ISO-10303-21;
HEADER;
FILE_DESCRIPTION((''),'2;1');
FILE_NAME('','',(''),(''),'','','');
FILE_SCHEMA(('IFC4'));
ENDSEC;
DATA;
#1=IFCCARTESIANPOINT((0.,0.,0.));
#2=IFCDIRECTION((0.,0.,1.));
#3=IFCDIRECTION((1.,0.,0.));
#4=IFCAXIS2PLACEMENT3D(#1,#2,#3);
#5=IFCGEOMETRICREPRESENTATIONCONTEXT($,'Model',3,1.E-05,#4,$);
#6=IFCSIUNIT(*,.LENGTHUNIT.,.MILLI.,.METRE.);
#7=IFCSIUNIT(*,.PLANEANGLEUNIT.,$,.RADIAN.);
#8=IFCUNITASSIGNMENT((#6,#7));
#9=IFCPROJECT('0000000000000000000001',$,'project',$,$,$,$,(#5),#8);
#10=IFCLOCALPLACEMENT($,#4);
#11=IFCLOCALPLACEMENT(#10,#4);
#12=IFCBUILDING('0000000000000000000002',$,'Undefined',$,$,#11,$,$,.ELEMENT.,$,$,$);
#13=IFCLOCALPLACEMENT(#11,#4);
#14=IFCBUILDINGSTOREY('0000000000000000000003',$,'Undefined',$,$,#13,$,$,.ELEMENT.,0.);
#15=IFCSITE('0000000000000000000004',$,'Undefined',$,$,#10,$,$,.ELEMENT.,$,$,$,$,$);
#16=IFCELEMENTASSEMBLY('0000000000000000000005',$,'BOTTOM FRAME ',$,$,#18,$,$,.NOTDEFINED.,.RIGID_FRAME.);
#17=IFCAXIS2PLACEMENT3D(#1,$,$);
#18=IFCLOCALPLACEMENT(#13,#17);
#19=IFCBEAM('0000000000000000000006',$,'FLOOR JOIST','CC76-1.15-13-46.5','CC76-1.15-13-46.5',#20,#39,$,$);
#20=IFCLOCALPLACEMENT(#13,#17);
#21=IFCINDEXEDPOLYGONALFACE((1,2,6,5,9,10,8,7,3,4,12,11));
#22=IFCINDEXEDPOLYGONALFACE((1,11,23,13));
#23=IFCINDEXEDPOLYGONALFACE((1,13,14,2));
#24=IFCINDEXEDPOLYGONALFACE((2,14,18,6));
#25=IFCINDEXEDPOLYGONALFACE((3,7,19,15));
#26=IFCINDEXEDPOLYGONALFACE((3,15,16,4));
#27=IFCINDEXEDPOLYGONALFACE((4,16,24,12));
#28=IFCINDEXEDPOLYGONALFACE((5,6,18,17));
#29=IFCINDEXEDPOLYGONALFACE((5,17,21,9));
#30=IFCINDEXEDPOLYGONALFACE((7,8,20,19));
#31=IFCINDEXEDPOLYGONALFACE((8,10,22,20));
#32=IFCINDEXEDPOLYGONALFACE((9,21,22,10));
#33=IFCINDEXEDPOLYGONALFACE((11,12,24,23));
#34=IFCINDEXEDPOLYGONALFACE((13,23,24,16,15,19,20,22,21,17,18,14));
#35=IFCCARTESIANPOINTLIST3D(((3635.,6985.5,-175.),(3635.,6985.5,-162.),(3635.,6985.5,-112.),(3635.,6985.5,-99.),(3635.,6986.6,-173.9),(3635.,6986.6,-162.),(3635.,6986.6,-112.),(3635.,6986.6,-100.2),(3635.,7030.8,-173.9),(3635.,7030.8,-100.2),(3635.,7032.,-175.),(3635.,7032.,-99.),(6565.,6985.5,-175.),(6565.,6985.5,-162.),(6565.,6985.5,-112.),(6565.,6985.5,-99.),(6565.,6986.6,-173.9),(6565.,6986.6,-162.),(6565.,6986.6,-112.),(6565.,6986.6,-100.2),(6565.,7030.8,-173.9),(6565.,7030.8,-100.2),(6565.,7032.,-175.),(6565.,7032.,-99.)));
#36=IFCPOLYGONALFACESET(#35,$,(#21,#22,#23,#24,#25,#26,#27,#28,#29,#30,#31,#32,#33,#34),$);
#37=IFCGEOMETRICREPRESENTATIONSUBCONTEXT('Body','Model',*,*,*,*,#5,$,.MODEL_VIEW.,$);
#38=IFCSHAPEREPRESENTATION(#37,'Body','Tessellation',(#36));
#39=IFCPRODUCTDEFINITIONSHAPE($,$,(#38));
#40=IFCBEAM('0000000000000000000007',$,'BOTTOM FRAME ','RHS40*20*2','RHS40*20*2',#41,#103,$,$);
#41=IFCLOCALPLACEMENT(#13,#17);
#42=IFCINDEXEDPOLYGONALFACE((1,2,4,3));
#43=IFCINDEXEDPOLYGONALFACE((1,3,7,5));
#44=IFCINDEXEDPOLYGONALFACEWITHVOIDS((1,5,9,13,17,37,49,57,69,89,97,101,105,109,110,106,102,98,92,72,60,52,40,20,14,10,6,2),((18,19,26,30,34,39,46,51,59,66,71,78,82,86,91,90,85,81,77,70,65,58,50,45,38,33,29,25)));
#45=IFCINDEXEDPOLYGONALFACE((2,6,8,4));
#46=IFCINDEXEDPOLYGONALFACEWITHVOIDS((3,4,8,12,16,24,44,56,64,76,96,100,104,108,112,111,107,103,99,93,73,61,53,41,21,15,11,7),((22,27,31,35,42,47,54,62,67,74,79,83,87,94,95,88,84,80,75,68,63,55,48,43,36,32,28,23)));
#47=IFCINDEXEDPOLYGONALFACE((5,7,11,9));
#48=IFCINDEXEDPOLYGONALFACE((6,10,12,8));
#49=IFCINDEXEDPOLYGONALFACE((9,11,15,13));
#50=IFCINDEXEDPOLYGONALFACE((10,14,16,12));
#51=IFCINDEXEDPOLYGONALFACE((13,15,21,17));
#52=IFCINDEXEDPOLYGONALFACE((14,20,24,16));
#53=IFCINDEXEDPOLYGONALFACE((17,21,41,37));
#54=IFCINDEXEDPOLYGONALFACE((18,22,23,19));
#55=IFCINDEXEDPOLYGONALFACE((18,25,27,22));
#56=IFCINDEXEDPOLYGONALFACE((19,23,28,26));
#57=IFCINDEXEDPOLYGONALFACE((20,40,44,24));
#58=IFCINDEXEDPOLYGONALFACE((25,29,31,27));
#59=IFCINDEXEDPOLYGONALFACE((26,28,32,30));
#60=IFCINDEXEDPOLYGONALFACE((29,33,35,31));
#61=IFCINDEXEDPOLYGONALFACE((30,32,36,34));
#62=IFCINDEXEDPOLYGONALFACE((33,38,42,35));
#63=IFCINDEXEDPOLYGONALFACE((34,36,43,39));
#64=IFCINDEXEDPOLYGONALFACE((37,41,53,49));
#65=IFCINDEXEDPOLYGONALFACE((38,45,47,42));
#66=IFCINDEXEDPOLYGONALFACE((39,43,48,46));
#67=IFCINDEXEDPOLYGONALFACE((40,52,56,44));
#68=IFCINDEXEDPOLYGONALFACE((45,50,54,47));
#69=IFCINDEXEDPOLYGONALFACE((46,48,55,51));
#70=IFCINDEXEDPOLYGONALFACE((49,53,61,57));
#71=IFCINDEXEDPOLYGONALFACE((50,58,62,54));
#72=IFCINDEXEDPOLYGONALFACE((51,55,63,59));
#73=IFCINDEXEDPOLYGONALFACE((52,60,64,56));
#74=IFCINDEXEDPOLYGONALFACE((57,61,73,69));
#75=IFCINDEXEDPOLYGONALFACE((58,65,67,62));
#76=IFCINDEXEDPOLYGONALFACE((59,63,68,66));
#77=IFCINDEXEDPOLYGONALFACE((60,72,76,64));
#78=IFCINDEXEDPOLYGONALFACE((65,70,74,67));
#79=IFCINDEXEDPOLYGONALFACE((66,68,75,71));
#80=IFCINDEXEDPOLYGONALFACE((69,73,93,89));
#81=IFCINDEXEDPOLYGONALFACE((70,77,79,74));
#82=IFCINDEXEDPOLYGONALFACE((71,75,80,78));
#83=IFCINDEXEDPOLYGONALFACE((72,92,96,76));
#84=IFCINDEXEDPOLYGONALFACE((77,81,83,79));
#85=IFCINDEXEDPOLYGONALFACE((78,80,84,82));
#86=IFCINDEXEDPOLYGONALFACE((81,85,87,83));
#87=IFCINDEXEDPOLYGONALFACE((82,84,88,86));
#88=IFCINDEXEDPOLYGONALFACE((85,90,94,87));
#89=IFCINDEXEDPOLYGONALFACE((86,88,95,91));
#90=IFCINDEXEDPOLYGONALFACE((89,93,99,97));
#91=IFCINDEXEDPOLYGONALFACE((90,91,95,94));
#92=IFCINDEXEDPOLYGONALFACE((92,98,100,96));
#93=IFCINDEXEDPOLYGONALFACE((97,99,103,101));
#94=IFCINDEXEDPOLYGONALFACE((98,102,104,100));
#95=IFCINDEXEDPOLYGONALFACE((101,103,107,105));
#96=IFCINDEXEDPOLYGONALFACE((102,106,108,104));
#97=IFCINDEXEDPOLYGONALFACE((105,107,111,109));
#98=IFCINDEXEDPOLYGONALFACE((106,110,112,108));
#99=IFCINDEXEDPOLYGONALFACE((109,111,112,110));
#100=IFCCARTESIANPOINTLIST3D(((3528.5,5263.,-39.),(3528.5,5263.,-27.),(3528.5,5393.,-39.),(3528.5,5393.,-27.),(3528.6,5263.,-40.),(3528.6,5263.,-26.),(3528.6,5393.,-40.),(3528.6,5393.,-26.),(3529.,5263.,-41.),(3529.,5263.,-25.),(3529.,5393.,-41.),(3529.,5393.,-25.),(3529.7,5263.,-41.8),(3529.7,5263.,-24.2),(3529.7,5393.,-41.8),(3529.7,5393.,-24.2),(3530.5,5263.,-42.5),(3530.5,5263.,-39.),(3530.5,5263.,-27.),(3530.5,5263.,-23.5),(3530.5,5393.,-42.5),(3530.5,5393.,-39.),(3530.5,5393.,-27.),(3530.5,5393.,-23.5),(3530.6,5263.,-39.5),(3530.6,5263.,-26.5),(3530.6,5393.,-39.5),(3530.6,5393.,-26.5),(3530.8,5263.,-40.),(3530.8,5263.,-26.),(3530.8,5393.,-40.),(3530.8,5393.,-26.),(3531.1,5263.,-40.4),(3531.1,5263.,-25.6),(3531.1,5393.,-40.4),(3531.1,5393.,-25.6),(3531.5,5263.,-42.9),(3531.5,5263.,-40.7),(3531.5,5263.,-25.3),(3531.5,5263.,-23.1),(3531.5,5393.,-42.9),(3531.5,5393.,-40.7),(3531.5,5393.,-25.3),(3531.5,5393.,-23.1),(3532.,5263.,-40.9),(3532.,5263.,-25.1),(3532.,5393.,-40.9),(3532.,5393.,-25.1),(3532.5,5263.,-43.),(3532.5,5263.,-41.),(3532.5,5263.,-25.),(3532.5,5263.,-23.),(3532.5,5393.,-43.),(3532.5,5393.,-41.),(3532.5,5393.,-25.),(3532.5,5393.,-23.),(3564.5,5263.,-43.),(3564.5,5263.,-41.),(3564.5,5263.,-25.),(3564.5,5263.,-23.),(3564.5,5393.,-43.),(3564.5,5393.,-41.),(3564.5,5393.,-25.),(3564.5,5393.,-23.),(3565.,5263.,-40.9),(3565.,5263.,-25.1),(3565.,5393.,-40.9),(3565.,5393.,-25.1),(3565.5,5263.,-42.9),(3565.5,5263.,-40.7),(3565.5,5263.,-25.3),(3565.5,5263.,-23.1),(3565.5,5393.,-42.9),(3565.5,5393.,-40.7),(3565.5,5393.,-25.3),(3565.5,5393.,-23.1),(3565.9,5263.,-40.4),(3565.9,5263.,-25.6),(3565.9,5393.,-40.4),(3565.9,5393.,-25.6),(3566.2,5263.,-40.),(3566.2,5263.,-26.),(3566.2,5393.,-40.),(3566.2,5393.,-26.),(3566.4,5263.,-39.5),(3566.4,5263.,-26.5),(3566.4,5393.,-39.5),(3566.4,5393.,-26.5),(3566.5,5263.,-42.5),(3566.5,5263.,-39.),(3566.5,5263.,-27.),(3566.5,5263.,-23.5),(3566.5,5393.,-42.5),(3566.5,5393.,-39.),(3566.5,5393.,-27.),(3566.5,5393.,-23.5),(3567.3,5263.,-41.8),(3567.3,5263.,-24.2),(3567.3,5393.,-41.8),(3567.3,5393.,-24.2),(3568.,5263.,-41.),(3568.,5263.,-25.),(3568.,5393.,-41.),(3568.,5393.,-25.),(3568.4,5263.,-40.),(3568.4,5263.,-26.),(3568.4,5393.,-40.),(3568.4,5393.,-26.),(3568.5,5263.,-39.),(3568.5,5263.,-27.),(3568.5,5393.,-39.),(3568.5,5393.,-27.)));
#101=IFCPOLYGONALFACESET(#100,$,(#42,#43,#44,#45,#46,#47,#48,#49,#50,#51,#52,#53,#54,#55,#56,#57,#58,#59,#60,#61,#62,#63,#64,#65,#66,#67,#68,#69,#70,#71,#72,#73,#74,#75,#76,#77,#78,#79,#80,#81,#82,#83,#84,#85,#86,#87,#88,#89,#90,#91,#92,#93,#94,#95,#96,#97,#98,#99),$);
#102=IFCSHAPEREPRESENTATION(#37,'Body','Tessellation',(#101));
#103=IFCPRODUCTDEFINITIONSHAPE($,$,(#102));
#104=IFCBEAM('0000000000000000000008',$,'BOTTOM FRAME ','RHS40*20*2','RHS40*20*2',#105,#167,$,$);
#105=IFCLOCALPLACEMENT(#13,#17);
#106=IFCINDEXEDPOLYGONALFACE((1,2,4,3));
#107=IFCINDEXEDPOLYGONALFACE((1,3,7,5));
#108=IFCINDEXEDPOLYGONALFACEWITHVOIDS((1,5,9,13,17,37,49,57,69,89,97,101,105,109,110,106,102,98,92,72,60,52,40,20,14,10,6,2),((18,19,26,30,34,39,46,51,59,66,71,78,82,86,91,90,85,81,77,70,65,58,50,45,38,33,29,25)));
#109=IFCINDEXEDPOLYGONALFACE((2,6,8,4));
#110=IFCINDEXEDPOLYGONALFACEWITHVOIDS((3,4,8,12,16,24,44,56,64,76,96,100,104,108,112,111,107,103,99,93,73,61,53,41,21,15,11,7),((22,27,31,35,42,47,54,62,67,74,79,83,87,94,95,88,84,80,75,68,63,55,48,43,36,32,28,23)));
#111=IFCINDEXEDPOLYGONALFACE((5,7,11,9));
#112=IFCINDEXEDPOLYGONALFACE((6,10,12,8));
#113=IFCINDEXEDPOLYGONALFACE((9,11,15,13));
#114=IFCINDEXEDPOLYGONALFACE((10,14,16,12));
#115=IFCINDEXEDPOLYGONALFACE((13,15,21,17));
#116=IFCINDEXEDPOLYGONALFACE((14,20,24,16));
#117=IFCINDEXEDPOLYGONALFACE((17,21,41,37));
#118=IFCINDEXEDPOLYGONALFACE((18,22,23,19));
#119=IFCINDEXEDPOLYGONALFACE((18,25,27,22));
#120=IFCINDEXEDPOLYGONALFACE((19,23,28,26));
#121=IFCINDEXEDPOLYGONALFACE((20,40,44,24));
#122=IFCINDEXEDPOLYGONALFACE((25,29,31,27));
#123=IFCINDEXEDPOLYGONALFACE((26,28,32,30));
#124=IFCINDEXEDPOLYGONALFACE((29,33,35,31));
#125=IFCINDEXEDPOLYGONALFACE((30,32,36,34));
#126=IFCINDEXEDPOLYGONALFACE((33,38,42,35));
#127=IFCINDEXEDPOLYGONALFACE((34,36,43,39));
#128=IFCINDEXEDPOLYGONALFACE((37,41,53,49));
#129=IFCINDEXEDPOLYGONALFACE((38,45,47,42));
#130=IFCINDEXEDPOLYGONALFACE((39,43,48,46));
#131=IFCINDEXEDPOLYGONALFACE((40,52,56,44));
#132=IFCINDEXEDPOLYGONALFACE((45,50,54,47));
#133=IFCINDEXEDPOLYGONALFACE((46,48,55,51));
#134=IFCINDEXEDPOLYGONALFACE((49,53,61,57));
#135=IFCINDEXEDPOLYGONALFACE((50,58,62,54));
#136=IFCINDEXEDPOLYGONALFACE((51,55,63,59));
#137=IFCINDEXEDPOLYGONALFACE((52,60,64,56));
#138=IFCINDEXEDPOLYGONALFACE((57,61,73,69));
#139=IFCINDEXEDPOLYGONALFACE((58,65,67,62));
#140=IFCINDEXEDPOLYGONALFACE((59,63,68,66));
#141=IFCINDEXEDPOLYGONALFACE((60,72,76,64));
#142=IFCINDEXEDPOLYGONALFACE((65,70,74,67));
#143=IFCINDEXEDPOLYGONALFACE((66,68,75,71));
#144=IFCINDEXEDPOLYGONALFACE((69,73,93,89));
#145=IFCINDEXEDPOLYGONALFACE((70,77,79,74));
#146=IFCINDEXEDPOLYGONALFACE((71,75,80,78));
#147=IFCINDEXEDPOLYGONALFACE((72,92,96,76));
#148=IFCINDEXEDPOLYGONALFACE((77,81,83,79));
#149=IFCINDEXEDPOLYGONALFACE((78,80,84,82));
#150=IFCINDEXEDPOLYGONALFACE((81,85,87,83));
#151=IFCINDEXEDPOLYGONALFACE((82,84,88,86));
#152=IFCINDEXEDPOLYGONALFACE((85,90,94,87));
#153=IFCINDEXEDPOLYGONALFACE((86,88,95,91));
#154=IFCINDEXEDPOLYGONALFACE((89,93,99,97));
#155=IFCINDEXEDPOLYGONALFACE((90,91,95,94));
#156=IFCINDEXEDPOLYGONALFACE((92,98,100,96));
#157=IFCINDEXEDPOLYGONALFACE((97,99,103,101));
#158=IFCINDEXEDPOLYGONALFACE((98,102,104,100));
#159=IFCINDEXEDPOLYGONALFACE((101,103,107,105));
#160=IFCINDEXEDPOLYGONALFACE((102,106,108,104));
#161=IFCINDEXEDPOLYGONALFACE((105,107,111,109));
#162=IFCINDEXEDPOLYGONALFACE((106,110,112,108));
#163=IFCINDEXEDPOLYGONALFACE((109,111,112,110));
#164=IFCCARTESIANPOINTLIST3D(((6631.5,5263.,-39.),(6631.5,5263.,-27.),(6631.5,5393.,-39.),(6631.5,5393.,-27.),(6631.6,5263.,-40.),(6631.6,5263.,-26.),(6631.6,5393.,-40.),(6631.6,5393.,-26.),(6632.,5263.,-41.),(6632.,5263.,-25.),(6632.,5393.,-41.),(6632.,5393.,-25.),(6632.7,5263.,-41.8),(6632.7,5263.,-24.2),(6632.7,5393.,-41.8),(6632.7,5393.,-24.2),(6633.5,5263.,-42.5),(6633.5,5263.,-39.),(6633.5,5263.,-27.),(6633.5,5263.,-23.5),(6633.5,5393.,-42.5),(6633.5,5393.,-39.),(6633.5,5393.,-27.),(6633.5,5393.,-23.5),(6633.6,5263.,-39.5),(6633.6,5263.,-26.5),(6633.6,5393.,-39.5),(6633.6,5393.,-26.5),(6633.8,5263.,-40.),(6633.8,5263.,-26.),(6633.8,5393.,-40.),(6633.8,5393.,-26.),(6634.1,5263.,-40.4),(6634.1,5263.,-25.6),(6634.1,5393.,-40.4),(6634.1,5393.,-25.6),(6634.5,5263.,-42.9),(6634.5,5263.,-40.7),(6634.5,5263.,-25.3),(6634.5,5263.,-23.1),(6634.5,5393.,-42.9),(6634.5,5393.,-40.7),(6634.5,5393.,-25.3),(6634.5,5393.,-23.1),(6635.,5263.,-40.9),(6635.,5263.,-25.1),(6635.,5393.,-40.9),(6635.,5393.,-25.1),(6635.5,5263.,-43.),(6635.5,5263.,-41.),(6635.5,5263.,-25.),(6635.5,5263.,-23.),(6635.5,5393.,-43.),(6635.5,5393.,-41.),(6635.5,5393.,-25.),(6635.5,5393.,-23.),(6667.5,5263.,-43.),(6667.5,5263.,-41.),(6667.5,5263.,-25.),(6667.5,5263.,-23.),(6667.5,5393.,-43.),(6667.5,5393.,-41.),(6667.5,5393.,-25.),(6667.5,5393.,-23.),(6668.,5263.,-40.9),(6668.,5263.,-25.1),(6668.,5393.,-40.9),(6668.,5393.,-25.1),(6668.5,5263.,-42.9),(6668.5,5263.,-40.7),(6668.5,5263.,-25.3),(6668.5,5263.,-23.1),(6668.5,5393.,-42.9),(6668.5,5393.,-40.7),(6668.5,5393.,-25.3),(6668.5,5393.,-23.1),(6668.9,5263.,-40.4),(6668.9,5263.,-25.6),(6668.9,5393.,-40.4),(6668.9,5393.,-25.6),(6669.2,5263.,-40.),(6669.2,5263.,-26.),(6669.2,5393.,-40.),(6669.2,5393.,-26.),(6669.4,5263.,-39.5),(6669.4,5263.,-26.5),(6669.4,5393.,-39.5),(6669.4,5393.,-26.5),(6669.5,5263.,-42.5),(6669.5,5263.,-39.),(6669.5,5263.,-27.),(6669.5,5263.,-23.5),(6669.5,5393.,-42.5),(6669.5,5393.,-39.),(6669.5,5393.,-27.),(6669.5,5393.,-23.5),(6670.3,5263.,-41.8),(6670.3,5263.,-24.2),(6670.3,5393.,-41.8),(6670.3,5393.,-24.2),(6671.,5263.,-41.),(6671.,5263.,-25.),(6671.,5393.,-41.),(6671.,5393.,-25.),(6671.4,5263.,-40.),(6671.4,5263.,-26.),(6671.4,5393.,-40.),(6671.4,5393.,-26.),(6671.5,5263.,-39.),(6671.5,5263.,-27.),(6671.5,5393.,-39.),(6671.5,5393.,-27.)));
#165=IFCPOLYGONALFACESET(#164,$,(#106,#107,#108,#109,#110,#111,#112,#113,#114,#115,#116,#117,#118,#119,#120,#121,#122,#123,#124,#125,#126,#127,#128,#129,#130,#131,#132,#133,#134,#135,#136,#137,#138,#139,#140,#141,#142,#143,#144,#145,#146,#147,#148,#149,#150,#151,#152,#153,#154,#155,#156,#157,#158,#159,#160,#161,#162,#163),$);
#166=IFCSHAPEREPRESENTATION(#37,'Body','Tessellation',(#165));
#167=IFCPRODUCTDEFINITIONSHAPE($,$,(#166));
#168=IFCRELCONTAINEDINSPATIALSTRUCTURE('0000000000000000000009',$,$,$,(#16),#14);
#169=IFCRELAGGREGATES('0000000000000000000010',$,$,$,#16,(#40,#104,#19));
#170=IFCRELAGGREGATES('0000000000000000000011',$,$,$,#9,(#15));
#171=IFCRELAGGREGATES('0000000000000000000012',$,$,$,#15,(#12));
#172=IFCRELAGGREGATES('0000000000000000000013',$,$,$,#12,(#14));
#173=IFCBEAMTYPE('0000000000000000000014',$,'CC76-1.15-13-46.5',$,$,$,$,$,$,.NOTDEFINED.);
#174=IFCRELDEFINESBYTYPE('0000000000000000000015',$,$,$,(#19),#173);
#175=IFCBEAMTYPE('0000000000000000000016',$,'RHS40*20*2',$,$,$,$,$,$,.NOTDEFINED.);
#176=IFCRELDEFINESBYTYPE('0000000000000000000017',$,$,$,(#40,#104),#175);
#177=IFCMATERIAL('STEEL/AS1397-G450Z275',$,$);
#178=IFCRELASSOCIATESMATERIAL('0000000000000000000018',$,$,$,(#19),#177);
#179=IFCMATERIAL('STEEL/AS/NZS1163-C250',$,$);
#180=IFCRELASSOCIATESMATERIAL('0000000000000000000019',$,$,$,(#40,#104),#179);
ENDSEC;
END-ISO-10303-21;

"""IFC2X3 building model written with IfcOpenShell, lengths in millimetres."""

from ifc_helpers import new_model, si_unit, frame, origin_with_axes, origin_2d_with_axis, place, context, subcontext, project, spatial, hollow_rectangle, c_section, extrude, material, type_object, element, aggregate, save


model = new_model("IFC2X3")

# Units and contexts
model_context = context("Model", 3, precision=1e-05, world=origin_with_axes())
body_context = subcontext(model_context, "Body", "Model", "MODEL_VIEW")
ifc_project = project(units=[si_unit("LENGTHUNIT", "METRE", prefix="MILLI"), si_unit("PLANEANGLEUNIT", "RADIAN")], contexts=[model_context])

# Site, building, storey
site_placement = place(None, origin_with_axes())
site = spatial("IfcSite", under=ifc_project, at=site_placement, Name="Undefined", CompositionType="ELEMENT")
building_placement = place(site_placement, origin_with_axes())
building = spatial("IfcBuilding", under=site, at=building_placement, Name="Undefined", CompositionType="ELEMENT")
storey_placement = place(building_placement, origin_with_axes())
storey = spatial("IfcBuildingStorey", under=building, at=storey_placement, Name="Undefined", CompositionType="ELEMENT", Elevation=0.0)

# Element assembly, beams
assembly_1_placement = place(storey_placement, origin_with_axes())
assembly_1 = element("IfcElementAssembly", 1, at=assembly_1_placement, inside=storey, Name="BOTTOM FRAME ", AssemblyPlace="NOTDEFINED", PredefinedType="RIGID_FRAME")
ifc_material_1 = material(Name="STEEL/AS1397-G450Z275")
beam_type_1 = type_object("IfcBeamType", Name="CC76-1.15-13-46.5", PredefinedType="NOTDEFINED")
beam_1_placement = place(assembly_1_placement, frame((3635.0, 7008.7, -137.0), z_axis=(0.0, 0.0, 1.0), x_axis=(1.0, 0.0, 0.0)))
beam_1 = element("IfcBeam", 2, at=beam_1_placement, type_object=beam_type_1, material=ifc_material_1, Name="FLOOR JOIST", Description="CC76-1.15-13-46.5", ObjectType="CC76-1.15-13-46.5", context=body_context, shape_type="SweptSolid", body=[
    extrude(c_section(Depth=76.0, Width=46.5, WallThickness=1.1, Girth=13.0, at=origin_2d_with_axis()), frame((2930.0, 0.0, 0.0), z_axis=(-1.0, 0.0, 0.0), x_axis=(0.0, -1.0, 0.0)), (0.0, 0.0, 1.0), 2930.0),
])
ifc_material_2 = material(Name="STEEL/AS/NZS1163-C250")
beam_type_2 = type_object("IfcBeamType", Name="RHS40*20*2", PredefinedType="NOTDEFINED")
beam_2_placement = place(assembly_1_placement, frame((3548.5, 5393.0, -33.0), z_axis=(1.0, 0.0, 0.0), x_axis=(0.0, -1.0, 0.0)))
beam_2 = element("IfcBeam", 3, at=beam_2_placement, type_object=beam_type_2, material=ifc_material_2, Name="BOTTOM FRAME ", Description="RHS40*20*2", ObjectType="RHS40*20*2", context=body_context, shape_type="SweptSolid", body=[
    extrude(hollow_rectangle(XDim=20.0, YDim=40.0, WallThickness=2.0, InnerFilletRadius=2.0, OuterFilletRadius=4.0, at=origin_2d_with_axis()), frame((130.0, 0.0, 0.0), z_axis=(-1.0, 0.0, 0.0), x_axis=(0.0, -1.0, 0.0)), (0.0, 0.0, 1.0), 130.0),
])
beam_3_placement = place(assembly_1_placement, frame((6651.5, 5393.0, -33.0), z_axis=(-1.0, 0.0, 0.0), x_axis=(0.0, -1.0, 0.0)))
beam_3 = element("IfcBeam", 4, at=beam_3_placement, type_object=beam_type_2, material=ifc_material_2, Name="BOTTOM FRAME ", Description="RHS40*20*2", ObjectType="RHS40*20*2", context=body_context, shape_type="SweptSolid", body=[
    extrude(hollow_rectangle(XDim=20.0, YDim=40.0, WallThickness=2.0, InnerFilletRadius=2.0, OuterFilletRadius=4.0, at=origin_2d_with_axis()), frame((130.0, 0.0, 0.0), z_axis=(-1.0, 0.0, 0.0), x_axis=(0.0, -1.0, 0.0)), (0.0, 0.0, 1.0), 130.0),
])

aggregate(assembly_1, [beam_2, beam_3, beam_1])

save(model, "model.ifc")
